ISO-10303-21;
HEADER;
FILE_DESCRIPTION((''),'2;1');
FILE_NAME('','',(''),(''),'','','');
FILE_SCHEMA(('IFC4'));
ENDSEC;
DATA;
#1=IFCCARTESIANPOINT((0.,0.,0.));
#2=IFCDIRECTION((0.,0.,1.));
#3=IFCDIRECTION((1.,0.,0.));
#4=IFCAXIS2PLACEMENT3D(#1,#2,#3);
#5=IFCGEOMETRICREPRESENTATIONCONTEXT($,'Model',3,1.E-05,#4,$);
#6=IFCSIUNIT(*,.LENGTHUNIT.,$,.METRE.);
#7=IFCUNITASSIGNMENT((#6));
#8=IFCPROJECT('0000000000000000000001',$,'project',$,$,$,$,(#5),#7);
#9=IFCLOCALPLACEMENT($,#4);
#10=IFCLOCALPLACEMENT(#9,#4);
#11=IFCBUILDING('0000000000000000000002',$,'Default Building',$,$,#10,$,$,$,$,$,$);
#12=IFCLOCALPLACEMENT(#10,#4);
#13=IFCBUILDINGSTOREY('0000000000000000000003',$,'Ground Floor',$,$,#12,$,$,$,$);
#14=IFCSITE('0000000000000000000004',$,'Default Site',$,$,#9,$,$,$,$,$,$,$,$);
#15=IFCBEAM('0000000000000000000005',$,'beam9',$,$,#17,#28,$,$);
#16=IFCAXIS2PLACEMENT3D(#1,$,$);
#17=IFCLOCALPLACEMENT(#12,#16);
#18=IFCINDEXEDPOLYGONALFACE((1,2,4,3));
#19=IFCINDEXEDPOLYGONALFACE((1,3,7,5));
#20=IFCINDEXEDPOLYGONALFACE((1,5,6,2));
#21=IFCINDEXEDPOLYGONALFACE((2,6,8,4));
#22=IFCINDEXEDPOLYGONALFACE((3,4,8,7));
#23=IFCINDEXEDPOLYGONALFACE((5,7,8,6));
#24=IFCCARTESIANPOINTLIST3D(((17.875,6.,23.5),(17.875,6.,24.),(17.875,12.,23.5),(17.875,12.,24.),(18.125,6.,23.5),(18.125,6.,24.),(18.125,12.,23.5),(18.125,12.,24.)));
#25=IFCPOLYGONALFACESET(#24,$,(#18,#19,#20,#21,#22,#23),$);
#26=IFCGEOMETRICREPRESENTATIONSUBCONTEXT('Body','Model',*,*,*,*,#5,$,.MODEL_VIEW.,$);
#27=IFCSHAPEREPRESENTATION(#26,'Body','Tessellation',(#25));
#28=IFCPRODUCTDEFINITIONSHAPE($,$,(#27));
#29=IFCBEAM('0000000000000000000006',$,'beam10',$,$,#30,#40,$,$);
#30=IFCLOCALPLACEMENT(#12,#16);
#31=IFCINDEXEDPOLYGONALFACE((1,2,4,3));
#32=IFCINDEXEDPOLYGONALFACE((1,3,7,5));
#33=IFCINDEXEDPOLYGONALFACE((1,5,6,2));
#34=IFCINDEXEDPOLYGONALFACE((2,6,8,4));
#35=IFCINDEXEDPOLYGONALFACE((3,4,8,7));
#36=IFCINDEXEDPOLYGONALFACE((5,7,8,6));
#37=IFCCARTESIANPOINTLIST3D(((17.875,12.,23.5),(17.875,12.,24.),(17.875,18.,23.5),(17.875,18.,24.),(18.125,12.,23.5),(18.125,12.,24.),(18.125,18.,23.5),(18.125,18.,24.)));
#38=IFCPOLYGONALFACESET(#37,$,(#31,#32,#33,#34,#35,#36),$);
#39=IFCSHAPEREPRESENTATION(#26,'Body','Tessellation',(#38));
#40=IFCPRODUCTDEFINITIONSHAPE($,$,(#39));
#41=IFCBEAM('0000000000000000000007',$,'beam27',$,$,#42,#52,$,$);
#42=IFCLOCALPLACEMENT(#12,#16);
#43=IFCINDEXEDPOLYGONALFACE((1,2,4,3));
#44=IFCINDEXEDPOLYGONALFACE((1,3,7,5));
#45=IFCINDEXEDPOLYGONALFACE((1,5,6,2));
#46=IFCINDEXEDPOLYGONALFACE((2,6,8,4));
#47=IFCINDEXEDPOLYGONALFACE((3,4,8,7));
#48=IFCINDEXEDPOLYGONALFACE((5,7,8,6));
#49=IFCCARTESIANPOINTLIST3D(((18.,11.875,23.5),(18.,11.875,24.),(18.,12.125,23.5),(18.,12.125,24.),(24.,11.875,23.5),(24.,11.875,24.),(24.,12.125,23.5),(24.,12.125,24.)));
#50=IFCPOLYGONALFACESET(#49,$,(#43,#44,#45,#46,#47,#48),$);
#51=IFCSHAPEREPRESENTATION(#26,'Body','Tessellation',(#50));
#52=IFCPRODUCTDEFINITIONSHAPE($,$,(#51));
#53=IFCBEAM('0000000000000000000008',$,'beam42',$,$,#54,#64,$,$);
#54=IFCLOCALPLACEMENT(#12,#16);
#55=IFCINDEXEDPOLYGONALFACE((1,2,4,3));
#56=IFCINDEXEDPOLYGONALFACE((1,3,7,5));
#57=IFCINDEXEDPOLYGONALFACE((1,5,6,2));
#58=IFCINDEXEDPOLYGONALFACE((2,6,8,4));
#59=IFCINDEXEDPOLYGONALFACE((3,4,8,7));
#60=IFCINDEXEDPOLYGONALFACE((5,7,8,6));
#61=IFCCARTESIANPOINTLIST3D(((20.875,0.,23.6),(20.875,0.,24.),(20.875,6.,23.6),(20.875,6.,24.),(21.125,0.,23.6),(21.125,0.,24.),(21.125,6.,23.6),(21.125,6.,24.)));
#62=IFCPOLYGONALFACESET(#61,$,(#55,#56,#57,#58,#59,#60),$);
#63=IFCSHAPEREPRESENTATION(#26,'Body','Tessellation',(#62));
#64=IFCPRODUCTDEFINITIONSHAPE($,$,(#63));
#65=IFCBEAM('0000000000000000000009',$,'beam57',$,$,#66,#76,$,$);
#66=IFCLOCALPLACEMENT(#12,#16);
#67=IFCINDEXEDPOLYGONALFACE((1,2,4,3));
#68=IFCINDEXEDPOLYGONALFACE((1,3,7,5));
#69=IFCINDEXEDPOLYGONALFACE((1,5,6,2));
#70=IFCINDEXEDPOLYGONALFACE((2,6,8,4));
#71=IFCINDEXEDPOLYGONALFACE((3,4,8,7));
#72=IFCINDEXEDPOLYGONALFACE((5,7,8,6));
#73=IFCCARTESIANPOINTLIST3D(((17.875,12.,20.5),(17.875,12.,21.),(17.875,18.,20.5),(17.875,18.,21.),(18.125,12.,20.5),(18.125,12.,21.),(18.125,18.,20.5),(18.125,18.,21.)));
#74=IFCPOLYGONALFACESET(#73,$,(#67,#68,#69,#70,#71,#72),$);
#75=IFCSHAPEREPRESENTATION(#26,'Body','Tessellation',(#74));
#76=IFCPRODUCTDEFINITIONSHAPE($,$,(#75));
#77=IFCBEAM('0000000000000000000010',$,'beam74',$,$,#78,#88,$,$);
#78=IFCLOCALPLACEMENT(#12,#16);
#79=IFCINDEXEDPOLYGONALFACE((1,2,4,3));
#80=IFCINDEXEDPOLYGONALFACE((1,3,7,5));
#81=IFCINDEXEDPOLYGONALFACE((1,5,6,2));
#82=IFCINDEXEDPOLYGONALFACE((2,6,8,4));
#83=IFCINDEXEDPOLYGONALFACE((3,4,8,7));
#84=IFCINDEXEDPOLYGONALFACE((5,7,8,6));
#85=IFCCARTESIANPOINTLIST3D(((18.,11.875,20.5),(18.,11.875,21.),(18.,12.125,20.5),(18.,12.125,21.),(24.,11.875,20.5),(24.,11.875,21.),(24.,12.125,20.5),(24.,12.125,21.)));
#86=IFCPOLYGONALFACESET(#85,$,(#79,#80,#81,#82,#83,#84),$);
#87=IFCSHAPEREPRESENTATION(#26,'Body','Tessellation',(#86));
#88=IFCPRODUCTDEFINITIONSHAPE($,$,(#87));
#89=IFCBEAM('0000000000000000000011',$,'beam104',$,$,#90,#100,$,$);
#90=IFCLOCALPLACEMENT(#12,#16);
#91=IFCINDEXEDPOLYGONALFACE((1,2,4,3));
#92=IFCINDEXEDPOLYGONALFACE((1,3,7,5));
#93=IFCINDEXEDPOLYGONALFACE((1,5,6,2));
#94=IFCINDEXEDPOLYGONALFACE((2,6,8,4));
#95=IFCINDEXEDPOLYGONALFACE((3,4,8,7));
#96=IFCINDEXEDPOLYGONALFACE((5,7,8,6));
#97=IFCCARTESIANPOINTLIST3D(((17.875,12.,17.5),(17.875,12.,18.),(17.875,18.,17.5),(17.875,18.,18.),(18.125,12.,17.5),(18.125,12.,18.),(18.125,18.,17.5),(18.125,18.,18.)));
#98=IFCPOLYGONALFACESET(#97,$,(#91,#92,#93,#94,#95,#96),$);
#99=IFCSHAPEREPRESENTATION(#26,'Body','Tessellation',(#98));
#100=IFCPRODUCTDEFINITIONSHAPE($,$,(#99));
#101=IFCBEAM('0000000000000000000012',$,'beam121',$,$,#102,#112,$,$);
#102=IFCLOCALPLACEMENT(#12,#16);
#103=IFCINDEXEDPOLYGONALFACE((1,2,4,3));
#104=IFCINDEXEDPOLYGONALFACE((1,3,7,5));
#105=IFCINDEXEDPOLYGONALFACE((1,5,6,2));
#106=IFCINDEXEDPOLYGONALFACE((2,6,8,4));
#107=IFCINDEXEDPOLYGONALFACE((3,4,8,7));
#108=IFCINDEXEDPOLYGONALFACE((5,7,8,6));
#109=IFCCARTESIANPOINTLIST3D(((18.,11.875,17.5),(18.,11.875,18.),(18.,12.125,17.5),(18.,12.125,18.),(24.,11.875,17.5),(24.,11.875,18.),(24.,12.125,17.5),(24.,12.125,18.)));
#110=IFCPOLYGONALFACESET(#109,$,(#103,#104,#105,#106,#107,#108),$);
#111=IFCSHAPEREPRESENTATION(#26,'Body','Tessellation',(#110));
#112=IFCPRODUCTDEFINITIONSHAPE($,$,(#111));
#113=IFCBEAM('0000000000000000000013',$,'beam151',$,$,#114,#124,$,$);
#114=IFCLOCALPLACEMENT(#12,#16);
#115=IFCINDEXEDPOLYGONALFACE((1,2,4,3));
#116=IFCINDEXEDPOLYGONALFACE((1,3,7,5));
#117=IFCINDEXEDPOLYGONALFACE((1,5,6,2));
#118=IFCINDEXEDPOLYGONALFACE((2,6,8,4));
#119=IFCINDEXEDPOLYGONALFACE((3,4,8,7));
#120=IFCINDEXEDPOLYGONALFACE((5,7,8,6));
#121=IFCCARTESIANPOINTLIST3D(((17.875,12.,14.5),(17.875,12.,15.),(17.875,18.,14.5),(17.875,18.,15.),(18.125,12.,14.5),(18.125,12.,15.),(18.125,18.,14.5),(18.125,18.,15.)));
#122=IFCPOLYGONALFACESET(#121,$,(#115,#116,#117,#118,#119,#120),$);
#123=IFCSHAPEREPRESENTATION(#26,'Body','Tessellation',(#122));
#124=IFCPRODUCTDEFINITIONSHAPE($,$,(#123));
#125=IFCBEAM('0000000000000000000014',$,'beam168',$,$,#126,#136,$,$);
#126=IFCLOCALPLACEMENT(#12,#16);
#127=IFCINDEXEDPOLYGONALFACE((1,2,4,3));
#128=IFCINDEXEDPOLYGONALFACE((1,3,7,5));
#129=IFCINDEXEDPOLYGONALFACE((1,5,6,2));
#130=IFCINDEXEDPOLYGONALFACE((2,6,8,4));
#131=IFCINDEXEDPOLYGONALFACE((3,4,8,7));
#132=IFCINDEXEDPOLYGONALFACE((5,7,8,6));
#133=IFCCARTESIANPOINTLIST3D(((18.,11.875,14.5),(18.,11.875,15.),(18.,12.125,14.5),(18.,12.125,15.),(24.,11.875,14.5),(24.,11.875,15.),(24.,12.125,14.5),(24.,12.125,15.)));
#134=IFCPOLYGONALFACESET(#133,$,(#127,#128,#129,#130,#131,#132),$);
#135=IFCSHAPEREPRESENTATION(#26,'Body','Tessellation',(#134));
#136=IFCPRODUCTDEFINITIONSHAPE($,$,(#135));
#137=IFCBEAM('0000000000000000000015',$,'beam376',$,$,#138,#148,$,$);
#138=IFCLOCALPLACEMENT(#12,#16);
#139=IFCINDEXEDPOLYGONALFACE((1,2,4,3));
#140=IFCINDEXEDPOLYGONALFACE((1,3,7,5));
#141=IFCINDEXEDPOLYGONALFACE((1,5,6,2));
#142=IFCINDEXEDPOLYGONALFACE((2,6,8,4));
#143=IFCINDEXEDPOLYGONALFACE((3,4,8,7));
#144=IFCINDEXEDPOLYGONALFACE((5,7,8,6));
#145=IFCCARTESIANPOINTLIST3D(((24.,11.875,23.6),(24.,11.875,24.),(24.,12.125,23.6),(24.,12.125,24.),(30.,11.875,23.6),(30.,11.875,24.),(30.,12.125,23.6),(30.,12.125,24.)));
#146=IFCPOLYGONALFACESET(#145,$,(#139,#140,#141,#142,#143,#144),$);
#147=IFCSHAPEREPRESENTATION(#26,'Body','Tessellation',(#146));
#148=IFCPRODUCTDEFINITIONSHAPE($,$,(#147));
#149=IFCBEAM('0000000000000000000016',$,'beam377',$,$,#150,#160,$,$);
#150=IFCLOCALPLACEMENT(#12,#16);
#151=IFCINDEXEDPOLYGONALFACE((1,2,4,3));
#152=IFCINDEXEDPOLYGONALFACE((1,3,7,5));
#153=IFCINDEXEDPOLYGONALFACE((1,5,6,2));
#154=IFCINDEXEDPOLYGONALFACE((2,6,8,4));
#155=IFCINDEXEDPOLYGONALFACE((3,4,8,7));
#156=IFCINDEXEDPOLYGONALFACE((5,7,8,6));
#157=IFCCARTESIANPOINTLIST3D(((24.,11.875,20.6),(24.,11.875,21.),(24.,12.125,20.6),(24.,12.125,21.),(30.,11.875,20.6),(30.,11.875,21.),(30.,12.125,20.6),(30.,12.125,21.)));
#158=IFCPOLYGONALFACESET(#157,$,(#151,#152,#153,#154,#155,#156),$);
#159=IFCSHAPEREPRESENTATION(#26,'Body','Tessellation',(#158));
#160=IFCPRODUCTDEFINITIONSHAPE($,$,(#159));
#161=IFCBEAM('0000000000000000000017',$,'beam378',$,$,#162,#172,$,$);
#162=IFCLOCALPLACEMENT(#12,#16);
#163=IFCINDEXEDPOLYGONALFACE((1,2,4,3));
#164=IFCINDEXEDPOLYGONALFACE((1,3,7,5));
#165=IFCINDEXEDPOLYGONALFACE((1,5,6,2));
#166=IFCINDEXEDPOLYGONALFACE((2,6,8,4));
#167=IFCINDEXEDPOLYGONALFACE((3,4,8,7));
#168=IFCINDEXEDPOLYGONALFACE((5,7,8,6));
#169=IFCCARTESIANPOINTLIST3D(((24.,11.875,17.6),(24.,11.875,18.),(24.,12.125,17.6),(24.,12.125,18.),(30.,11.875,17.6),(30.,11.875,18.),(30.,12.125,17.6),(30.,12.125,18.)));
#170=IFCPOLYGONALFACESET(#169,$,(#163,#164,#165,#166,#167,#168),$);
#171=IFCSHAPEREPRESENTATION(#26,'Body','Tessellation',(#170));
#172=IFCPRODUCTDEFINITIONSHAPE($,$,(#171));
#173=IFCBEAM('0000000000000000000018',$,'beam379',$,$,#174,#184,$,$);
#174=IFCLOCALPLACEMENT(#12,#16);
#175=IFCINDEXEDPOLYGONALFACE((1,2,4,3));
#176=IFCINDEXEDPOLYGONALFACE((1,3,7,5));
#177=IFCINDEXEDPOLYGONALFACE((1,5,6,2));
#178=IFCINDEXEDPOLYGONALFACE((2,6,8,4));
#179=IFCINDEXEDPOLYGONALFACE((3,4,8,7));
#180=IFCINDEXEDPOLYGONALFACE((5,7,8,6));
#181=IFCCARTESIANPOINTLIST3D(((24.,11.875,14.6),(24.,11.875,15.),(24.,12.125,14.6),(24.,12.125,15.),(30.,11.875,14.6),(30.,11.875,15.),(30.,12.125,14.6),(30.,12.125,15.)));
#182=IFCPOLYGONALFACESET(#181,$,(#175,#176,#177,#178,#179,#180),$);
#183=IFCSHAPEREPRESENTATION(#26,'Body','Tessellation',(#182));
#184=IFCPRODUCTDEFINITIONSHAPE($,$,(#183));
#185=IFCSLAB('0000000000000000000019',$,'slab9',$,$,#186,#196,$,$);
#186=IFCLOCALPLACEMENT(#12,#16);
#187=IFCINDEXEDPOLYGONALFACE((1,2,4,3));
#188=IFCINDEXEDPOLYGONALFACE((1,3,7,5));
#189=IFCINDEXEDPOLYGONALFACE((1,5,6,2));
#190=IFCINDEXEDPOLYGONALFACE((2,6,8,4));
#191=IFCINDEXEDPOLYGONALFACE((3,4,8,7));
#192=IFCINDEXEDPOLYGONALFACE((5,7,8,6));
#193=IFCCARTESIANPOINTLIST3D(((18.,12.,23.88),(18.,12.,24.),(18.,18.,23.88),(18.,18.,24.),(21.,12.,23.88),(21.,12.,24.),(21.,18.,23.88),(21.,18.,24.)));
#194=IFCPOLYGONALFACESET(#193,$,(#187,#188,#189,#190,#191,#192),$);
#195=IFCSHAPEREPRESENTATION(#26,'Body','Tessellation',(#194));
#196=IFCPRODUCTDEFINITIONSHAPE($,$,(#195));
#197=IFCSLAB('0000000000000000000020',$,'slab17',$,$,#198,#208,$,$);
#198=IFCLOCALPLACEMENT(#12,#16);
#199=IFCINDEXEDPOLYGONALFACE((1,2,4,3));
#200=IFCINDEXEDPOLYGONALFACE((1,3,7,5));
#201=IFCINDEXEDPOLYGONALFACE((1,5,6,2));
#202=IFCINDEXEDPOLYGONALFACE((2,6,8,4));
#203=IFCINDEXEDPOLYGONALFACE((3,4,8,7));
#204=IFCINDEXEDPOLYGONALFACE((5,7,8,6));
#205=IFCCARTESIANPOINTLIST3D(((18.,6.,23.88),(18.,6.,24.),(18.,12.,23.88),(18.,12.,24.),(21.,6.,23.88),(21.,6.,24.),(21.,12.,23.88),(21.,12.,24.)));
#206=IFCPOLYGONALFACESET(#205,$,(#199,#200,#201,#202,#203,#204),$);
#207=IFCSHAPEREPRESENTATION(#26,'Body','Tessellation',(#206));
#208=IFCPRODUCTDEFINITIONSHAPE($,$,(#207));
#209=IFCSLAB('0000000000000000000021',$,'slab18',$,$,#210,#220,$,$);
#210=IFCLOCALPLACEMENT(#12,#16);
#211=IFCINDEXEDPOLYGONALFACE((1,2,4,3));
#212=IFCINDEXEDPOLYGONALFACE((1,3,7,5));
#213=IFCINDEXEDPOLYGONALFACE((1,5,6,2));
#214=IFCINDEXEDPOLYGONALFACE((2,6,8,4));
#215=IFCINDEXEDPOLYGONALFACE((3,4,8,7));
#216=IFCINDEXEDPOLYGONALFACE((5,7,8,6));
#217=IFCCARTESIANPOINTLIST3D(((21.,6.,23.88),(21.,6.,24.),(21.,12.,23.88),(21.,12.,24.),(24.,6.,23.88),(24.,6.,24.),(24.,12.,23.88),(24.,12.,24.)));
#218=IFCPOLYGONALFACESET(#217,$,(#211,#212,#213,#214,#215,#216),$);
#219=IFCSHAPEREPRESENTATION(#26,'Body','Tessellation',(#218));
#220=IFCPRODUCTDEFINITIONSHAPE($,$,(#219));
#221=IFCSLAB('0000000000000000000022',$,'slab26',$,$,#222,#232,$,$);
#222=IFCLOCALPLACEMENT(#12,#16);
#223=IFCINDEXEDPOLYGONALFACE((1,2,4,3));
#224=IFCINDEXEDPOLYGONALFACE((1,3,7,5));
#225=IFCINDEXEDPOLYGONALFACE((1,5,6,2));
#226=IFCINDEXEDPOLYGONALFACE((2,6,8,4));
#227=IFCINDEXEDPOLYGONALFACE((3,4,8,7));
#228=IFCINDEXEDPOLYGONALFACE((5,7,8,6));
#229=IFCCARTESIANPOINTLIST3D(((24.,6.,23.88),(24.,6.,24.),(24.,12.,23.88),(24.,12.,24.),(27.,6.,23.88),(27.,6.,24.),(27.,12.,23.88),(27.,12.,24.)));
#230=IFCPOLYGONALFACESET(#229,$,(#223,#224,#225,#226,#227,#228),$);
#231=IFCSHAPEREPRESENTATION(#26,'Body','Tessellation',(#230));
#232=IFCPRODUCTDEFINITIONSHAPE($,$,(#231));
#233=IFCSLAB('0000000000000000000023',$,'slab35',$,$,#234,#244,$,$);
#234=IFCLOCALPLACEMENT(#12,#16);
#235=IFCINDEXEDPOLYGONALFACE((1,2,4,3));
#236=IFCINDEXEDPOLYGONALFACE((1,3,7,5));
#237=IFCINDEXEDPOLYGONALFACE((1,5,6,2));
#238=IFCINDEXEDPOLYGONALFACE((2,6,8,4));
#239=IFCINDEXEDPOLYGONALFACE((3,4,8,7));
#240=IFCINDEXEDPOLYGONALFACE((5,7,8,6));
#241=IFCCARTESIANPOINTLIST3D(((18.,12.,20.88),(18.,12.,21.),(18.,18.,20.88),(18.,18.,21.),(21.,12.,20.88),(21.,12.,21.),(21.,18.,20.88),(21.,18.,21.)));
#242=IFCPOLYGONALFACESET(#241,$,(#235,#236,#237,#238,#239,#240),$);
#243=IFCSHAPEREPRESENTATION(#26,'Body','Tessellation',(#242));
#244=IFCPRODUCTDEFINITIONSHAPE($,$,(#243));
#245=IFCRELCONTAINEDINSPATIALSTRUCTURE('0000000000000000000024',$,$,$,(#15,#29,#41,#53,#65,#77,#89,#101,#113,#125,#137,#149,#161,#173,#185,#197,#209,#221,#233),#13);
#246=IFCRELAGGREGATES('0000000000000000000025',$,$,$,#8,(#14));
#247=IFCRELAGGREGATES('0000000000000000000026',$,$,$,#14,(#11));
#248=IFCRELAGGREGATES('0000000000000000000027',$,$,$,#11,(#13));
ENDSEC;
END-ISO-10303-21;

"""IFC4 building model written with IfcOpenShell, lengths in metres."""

from ifc_helpers import new_model, si_unit, frame, origin_with_axes, place, context, subcontext, project, spatial, indexed_curve, outline, extrude, element, save


model = new_model("IFC4")

# Units and contexts
model_context = context("Model", 3, precision=1e-05, world=origin_with_axes())
body_context = subcontext(model_context, "Body", "Model", "MODEL_VIEW")
ifc_project = project(units=[si_unit("LENGTHUNIT", "METRE")], contexts=[model_context])

# Site, building, storey
site_placement = place(None, origin_with_axes())
site = spatial("IfcSite", under=ifc_project, at=site_placement, Name="Default Site")
building_placement = place(site_placement, origin_with_axes())
building = spatial("IfcBuilding", under=site, at=building_placement, Name="Default Building")
storey_placement = place(building_placement, origin_with_axes())
storey = spatial("IfcBuildingStorey", under=building, at=storey_placement, Name="Ground Floor")

# Beams
for number, where, z_axis, x_axis, name in (
    (1, (18.125, 6.0, 23.5), (0.0, 0.0, 1.0), (0.0, 1.0, 0.0), "beam9"),
    (2, (18.125, 12.0, 23.5), (0.0, 0.0, 1.0), (0.0, 1.0, 0.0), "beam10"),
    (3, (18.0, 11.875, 23.5), (0.0, 0.0, 1.0), (1.0, 0.0, 0.0), "beam27"),
):
    element("IfcBeam", number, at=place(storey_placement, frame(where, z_axis=z_axis, x_axis=x_axis)), inside=storey, Name=name, context=body_context, shape_type="SweptSolid", body=[
        extrude(outline(indexed_curve([(0.0, 0.0), (0.0, 0.25), (6.0, 0.25), (6.0, 0.0), (0.0, 0.0)], self_intersect=False)), origin_with_axes(), (0.0, 0.0, 1.0), 0.5),
    ])
beam_placement = place(storey_placement, frame((20.875, 6.0, 23.6), z_axis=(0.0, 0.0, 1.0), x_axis=(0.0, -1.0, 0.0)))
element("IfcBeam", 4, at=beam_placement, inside=storey, Name="beam42", context=body_context, shape_type="SweptSolid", body=[
    extrude(outline(indexed_curve([(0.0, 0.0), (0.0, 0.25), (6.0, 0.25), (6.0, 0.0), (0.0, 0.0)], self_intersect=False)), origin_with_axes(), (0.0, 0.0, 1.0), 0.4),
])
for number, where, z_axis, x_axis, name in (
    (5, (18.125, 12.0, 20.5), (0.0, 0.0, 1.0), (0.0, 1.0, 0.0), "beam57"),
    (6, (18.0, 11.875, 20.5), (0.0, 0.0, 1.0), (1.0, 0.0, 0.0), "beam74"),
    (7, (18.125, 12.0, 17.5), (0.0, 0.0, 1.0), (0.0, 1.0, 0.0), "beam104"),
    (8, (18.0, 11.875, 17.5), (0.0, 0.0, 1.0), (1.0, 0.0, 0.0), "beam121"),
    (9, (18.125, 12.0, 14.5), (0.0, 0.0, 1.0), (0.0, 1.0, 0.0), "beam151"),
    (10, (18.0, 11.875, 14.5), (0.0, 0.0, 1.0), (1.0, 0.0, 0.0), "beam168"),
):
    element("IfcBeam", number, at=place(storey_placement, frame(where, z_axis=z_axis, x_axis=x_axis)), inside=storey, Name=name, context=body_context, shape_type="SweptSolid", body=[
        extrude(outline(indexed_curve([(0.0, 0.0), (0.0, 0.25), (6.0, 0.25), (6.0, 0.0), (0.0, 0.0)], self_intersect=False)), origin_with_axes(), (0.0, 0.0, 1.0), 0.5),
    ])
for number, where, z_axis, x_axis, name in (
    (11, (24.0, 11.875, 23.6), (0.0, 0.0, 1.0), (1.0, 0.0, 0.0), "beam376"),
    (12, (24.0, 11.875, 20.6), (0.0, 0.0, 1.0), (1.0, 0.0, 0.0), "beam377"),
    (13, (24.0, 11.875, 17.6), (0.0, 0.0, 1.0), (1.0, 0.0, 0.0), "beam378"),
    (14, (24.0, 11.875, 14.6), (0.0, 0.0, 1.0), (1.0, 0.0, 0.0), "beam379"),
):
    element("IfcBeam", number, at=place(storey_placement, frame(where, z_axis=z_axis, x_axis=x_axis)), inside=storey, Name=name, context=body_context, shape_type="SweptSolid", body=[
        extrude(outline(indexed_curve([(0.0, 0.0), (0.0, 0.25), (6.0, 0.25), (6.0, 0.0), (0.0, 0.0)], self_intersect=False)), origin_with_axes(), (0.0, 0.0, 1.0), 0.4),
    ])

# Slabs
for number, where, z_axis, x_axis, name in (
    (15, (18.0, 12.0, 23.88), (0.0, 0.0, 1.0), (1.0, 0.0, 0.0), "slab9"),
    (16, (18.0, 6.0, 23.88), (0.0, 0.0, 1.0), (1.0, 0.0, 0.0), "slab17"),
    (17, (21.0, 6.0, 23.88), (0.0, 0.0, 1.0), (1.0, 0.0, 0.0), "slab18"),
    (18, (24.0, 6.0, 23.88), (0.0, 0.0, 1.0), (1.0, 0.0, 0.0), "slab26"),
    (19, (18.0, 12.0, 20.88), (0.0, 0.0, 1.0), (1.0, 0.0, 0.0), "slab35"),
):
    element("IfcSlab", number, at=place(storey_placement, frame(where, z_axis=z_axis, x_axis=x_axis)), inside=storey, Name=name, context=body_context, shape_type="SweptSolid", body=[
        extrude(outline(indexed_curve([(0.0, 0.0), (0.0, 6.0), (3.0, 6.0), (3.0, 0.0), (0.0, 0.0)], self_intersect=False)), origin_with_axes(), (0.0, 0.0, 1.0), 0.12),
    ])

save(model, "model.ifc")
